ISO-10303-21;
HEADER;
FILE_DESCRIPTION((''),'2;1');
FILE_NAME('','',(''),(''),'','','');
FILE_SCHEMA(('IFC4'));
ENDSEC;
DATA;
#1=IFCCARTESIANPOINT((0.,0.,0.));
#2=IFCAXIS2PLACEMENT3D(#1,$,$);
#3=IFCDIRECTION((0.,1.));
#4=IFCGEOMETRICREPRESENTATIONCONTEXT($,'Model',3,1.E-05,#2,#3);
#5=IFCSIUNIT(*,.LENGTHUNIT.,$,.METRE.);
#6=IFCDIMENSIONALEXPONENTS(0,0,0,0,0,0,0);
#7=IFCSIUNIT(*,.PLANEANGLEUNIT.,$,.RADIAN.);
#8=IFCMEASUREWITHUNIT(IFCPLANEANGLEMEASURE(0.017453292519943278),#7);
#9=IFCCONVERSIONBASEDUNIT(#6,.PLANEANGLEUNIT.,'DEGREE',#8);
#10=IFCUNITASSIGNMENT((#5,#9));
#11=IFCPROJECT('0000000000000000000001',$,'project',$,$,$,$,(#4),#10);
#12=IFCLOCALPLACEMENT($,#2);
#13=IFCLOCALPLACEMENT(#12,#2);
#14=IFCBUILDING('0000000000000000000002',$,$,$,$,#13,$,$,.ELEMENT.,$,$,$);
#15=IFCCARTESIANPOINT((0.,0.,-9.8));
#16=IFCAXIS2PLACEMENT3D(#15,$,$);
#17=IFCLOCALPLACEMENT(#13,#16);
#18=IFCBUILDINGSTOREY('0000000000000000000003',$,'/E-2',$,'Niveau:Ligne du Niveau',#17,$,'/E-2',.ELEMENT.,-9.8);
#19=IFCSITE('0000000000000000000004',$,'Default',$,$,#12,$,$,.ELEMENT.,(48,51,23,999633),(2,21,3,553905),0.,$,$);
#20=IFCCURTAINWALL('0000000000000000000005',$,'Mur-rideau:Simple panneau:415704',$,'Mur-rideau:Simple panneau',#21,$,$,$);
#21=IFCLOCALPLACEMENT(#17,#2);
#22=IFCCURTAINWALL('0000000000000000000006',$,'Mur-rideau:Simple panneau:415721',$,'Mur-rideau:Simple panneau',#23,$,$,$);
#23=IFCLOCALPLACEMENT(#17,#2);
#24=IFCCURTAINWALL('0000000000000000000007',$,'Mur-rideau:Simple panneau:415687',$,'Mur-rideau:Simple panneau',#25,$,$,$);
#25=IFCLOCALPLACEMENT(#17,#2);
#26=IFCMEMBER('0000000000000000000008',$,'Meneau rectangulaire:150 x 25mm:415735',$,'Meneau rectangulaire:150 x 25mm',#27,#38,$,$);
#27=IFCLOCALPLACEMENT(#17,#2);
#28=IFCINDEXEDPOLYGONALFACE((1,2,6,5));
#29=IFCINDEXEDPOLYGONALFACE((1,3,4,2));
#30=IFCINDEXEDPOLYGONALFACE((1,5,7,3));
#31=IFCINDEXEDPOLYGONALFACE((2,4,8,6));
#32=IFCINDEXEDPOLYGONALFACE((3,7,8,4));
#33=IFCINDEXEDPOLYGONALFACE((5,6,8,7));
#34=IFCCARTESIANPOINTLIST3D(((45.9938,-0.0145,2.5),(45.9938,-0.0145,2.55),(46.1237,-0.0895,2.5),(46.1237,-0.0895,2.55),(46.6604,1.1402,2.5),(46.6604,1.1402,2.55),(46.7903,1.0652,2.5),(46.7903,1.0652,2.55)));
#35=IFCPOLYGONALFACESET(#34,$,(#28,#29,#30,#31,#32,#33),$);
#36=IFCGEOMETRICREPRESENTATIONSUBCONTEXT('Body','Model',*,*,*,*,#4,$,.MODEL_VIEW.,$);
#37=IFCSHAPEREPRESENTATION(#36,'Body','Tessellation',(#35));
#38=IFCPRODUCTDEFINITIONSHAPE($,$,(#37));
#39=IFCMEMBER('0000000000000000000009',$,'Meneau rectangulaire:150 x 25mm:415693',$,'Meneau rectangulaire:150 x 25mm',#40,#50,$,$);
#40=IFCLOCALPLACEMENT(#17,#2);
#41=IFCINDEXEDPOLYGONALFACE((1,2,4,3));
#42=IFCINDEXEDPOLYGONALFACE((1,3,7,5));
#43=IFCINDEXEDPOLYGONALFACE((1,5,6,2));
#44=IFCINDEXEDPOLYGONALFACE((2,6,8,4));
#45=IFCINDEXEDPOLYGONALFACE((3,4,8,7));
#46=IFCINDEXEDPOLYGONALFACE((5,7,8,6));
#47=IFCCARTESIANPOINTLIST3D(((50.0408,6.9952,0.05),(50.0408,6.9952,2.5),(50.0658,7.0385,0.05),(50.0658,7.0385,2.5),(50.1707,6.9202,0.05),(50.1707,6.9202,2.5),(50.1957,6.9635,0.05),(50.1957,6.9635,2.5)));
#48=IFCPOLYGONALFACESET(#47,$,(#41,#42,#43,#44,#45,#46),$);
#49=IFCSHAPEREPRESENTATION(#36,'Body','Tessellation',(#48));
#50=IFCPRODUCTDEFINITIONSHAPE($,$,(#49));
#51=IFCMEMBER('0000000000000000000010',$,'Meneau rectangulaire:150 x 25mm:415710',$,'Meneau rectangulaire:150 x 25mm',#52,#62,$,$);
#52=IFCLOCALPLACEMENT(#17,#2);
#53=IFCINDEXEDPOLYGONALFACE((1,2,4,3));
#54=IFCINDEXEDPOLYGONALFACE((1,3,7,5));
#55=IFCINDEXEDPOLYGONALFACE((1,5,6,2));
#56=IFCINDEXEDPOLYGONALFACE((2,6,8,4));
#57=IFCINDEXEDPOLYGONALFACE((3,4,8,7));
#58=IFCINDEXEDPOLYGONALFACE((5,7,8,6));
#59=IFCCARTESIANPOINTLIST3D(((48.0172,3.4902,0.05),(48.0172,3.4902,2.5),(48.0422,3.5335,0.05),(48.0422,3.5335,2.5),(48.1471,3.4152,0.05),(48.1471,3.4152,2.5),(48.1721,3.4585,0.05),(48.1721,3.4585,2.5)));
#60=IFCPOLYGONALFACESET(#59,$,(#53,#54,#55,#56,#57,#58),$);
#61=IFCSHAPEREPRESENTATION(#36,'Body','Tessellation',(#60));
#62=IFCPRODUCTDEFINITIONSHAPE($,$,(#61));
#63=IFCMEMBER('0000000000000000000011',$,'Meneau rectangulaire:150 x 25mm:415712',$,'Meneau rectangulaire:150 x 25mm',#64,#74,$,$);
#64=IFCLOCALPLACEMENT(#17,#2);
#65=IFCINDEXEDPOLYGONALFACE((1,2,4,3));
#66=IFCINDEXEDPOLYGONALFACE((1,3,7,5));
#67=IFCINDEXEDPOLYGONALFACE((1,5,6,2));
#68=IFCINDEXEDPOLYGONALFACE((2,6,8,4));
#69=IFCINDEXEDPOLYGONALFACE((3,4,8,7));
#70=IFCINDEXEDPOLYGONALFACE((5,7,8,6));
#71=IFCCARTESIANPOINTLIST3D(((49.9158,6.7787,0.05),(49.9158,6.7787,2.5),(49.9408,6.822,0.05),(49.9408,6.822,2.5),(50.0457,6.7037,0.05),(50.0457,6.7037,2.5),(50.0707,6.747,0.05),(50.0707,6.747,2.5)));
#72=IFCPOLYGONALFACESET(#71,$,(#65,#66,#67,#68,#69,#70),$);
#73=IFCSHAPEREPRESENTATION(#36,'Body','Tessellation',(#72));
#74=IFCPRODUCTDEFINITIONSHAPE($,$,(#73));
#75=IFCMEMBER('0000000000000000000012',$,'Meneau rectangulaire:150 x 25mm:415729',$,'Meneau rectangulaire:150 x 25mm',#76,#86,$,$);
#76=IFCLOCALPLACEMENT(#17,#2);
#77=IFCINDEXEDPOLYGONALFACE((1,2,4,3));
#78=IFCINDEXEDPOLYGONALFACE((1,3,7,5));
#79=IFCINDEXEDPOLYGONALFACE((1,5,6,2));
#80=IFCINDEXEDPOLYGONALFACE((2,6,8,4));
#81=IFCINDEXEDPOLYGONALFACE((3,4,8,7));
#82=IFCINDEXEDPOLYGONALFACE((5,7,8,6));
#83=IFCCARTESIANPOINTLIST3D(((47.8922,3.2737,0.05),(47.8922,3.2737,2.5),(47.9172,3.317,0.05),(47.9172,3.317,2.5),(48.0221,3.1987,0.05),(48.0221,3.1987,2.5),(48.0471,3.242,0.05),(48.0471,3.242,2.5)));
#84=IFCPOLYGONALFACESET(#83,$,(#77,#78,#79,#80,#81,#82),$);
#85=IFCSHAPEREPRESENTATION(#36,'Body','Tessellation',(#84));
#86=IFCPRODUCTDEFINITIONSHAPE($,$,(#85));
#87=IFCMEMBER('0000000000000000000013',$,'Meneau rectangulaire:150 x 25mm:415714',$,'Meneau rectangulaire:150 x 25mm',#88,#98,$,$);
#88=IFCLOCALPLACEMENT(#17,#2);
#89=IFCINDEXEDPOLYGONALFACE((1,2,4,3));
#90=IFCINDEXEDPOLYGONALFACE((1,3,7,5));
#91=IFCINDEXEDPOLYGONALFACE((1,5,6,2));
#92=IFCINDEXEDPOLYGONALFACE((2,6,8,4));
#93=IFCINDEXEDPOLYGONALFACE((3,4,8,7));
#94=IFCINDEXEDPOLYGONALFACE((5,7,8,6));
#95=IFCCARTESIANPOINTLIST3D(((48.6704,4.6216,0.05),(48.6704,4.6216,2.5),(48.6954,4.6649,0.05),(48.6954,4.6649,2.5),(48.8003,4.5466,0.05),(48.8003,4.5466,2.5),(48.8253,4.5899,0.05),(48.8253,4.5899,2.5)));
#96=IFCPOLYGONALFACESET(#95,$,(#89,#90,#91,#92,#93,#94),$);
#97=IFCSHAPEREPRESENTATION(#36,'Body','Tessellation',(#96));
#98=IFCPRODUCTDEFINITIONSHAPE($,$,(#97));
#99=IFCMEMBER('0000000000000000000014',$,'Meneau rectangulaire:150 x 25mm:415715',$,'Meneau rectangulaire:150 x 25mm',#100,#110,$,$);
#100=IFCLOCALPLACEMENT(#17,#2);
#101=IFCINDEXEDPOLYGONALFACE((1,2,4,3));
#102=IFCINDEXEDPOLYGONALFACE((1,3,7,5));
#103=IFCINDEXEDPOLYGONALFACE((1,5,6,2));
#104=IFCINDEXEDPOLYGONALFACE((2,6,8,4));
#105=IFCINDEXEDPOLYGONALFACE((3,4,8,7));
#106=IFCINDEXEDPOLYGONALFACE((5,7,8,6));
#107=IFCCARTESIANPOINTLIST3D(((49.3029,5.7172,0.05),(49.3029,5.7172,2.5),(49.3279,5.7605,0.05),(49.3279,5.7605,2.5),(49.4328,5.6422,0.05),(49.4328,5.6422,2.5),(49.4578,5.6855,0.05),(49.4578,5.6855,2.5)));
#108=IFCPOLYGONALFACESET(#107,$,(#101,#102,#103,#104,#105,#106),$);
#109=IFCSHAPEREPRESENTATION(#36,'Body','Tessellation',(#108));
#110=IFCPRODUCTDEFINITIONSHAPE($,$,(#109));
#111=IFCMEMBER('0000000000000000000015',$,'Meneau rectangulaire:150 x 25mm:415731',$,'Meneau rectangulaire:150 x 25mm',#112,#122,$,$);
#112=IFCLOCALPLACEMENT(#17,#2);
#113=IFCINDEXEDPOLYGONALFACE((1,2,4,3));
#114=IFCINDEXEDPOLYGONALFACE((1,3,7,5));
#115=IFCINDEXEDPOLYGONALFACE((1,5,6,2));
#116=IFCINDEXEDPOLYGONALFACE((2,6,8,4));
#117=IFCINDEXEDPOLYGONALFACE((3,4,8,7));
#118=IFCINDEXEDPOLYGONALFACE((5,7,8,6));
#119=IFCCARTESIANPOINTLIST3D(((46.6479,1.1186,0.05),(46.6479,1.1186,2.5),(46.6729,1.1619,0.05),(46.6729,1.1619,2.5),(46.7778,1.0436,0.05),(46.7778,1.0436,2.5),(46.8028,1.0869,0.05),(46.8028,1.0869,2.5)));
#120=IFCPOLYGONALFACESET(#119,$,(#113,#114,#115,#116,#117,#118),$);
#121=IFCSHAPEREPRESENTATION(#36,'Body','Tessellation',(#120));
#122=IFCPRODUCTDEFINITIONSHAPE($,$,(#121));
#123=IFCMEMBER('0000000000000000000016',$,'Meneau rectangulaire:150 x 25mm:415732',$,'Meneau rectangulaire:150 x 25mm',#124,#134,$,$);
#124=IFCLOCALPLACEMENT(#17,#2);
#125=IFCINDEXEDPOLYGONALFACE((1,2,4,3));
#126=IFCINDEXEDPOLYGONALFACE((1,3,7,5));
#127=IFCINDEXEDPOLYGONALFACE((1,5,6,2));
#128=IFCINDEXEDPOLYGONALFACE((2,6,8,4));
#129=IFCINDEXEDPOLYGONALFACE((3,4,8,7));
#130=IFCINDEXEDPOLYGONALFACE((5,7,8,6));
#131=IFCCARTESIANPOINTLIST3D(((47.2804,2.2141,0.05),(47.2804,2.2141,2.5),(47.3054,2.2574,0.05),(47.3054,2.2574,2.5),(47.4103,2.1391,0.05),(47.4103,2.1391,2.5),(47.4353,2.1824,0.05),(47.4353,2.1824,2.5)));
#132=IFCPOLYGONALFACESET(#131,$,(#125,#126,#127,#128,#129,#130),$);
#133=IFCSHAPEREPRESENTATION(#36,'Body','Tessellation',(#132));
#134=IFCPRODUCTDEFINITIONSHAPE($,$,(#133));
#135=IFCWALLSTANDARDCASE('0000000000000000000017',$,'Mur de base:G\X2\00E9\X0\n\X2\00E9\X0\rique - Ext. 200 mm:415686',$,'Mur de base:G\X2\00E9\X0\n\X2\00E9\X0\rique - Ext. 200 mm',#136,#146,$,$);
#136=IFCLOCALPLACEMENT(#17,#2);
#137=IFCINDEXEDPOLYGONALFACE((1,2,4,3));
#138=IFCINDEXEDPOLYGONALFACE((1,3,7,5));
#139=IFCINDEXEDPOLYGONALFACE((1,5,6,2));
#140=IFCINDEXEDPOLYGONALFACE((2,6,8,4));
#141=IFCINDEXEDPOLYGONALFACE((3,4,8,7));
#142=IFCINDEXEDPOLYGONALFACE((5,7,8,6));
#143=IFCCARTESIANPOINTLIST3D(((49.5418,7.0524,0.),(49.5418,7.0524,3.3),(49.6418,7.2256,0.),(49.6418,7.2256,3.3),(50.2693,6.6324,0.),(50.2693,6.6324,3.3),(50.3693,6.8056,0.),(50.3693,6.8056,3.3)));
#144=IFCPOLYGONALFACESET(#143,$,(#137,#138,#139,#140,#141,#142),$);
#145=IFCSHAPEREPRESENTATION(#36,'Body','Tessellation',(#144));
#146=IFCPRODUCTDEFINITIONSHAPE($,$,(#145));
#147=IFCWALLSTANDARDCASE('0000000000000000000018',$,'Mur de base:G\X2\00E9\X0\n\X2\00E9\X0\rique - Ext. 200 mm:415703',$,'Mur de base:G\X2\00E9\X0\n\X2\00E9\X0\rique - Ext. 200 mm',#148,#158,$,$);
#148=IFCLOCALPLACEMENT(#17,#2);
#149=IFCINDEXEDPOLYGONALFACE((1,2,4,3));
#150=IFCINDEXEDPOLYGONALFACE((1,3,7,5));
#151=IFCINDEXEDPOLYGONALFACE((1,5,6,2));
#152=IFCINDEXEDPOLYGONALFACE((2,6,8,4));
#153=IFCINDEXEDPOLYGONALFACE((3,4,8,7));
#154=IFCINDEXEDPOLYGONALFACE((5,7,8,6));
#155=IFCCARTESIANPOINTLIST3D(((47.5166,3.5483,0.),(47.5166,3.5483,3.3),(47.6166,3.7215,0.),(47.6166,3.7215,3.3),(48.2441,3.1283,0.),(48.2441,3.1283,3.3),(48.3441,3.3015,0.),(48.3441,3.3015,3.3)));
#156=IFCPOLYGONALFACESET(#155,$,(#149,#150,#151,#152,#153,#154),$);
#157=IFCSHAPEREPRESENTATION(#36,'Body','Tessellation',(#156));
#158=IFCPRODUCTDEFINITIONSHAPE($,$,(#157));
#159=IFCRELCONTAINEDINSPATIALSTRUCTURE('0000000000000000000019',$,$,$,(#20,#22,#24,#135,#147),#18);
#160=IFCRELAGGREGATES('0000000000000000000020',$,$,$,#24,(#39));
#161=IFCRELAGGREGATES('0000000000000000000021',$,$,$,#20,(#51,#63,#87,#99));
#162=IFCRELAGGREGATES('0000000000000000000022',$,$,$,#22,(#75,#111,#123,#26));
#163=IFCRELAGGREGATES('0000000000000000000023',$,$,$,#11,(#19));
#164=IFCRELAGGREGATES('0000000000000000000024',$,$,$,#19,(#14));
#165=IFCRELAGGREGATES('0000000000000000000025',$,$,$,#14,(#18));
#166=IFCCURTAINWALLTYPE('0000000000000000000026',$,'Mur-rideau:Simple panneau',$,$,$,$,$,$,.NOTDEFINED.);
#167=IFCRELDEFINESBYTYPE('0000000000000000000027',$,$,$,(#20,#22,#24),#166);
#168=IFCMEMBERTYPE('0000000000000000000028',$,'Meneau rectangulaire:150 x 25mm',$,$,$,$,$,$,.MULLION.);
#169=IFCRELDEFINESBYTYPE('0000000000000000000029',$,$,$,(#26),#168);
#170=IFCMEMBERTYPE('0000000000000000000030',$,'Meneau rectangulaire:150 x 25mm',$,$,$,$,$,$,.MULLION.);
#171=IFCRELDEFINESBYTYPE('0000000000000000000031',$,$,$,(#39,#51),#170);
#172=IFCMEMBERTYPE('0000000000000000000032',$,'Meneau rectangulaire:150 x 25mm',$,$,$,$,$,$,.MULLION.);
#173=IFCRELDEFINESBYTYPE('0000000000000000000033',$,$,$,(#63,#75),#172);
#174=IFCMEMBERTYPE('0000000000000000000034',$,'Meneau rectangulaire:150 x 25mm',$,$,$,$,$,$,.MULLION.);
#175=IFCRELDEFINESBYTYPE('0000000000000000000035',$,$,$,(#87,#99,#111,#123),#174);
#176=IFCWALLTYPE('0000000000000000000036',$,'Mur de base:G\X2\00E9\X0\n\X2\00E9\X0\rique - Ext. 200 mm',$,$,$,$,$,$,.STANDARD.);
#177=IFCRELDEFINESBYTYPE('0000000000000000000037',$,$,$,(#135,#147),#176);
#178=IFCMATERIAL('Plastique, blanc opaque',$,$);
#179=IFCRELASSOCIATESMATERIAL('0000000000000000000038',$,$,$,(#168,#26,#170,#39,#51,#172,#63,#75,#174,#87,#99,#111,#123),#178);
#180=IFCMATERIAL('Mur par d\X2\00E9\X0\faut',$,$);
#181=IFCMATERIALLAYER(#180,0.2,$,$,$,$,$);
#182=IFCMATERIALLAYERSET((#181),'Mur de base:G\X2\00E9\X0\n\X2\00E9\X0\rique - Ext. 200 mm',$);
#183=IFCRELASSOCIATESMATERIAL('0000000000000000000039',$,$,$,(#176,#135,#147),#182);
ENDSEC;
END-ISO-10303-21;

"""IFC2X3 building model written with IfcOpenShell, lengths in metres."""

from ifc_helpers import new_model, entity, si_unit, converted_unit, direction, frame, frame_2d, origin, origin_2d_with_axis, place, context, subcontext, project, spatial, rectangle, extrude, source, transform, mapped, material, layer, layer_set, layer_usage, type_object, type_shapes, element, aggregate, save


model = new_model("IFC2X3")

# Units and contexts
model_context = context("Model", 3, precision=1e-05, world=origin(), true_north=direction((0.0, 1.0)))
body_context = subcontext(model_context, "Body", "Model", "MODEL_VIEW")
ifc_project = project(units=[si_unit("LENGTHUNIT", "METRE"), converted_unit("PLANEANGLEUNIT", "DEGREE", entity("IfcPlaneAngleMeasure", 0.017453292519943278), si_unit("PLANEANGLEUNIT", "RADIAN"), dimensions=[0, 0, 0, 0, 0, 0, 0])], contexts=[model_context])

# Site, building, storey
site_placement = place(None, origin())
site = spatial("IfcSite", under=ifc_project, at=site_placement, Name="Default", CompositionType="ELEMENT", RefLatitude=(48, 51, 23, 999633), RefLongitude=(2, 21, 3, 553905), RefElevation=0.0)
building_placement = place(site_placement, origin())
building = spatial("IfcBuilding", under=site, at=building_placement, CompositionType="ELEMENT")
storey_placement = place(building_placement, frame((0.0, 0.0, -9.8)))
storey = spatial("IfcBuildingStorey", under=building, at=storey_placement, Name="/E-2", ObjectType="Niveau:Ligne du Niveau", LongName="/E-2", CompositionType="ELEMENT", Elevation=-9.8)

# Curtain walls
curtain_wall_type = type_object("IfcCurtainWallType", Name="Mur-rideau:Simple panneau", PredefinedType="NOTDEFINED")
curtain_wall_1_placement = place(storey_placement, frame((0.0, 0.0, 9.8)))
curtain_wall_1 = element("IfcCurtainWall", 1, at=curtain_wall_1_placement, inside=storey, type_object=curtain_wall_type, Name="Mur-rideau:Simple panneau:415704", ObjectType="Mur-rideau:Simple panneau")
ifc_material_1 = material(Name="Plastique, blanc opaque")
curtain_wall_2_placement = place(storey_placement, frame((0.0, 0.0, 9.8)))
curtain_wall_2 = element("IfcCurtainWall", 2, at=curtain_wall_2_placement, inside=storey, type_object=curtain_wall_type, Name="Mur-rideau:Simple panneau:415721", ObjectType="Mur-rideau:Simple panneau")

# Curtain wall
curtain_wall_3_placement = place(storey_placement, frame((0.0, 0.0, 9.8)))
curtain_wall_3 = element("IfcCurtainWall", 3, at=curtain_wall_3_placement, inside=storey, type_object=curtain_wall_type, Name="Mur-rideau:Simple panneau:415687", ObjectType="Mur-rideau:Simple panneau")

# Members
member_type_1 = type_object("IfcMemberType", Name="Meneau rectangulaire:150 x 25mm", PredefinedType="MULLION", material=ifc_material_1)
shared_shape_1 = source(origin(), body_context, "Body", "SweptSolid", [
    extrude(rectangle(XDim=0.05, YDim=0.15, at=origin_2d_with_axis()), frame((-0.025, 0.0, -1.3333), z_axis=(0.0, 0.0, 1.0), x_axis=(-1.0, 0.0, 0.0)), (0.0, 0.0, 1.0), 1.3333),
])
type_shapes(member_type_1, [shared_shape_1])
member_1_placement = place(curtain_wall_2_placement, frame((46.7254, 1.1027, -7.25), z_axis=(0.5, 0.866025, 0.0), x_axis=(0.0, 0.0, 1.0)))
member_1 = element("IfcMember", 4, at=member_1_placement, type_object=member_type_1, material=ifc_material_1, Name="Meneau rectangulaire:150 x 25mm:415735", ObjectType="Meneau rectangulaire:150 x 25mm", context=body_context, shape_type="MappedRepresentation", body=[
    mapped(shared_shape_1, transform((0.0, 0.0, 0.0), scale=1.0)),
])
member_type_2 = type_object("IfcMemberType", Name="Meneau rectangulaire:150 x 25mm", PredefinedType="MULLION", material=ifc_material_1)
shared_shape_2 = source(origin(), body_context, "Body", "SweptSolid", [
    extrude(rectangle(XDim=0.05, YDim=0.15, at=origin_2d_with_axis()), frame((-0.025, 0.0, -2.45), z_axis=(0.0, 0.0, 1.0), x_axis=(-1.0, 0.0, 0.0)), (0.0, 0.0, 1.0), 2.45),
])
type_shapes(member_type_2, [shared_shape_2])
member_2_placement = place(curtain_wall_3_placement, frame((50.1058, 6.9577, -7.3), z_axis=(0.0, 0.0, 1.0), x_axis=(-0.5, -0.866025, 0.0)))
member_2 = element("IfcMember", 5, at=member_2_placement, type_object=member_type_2, material=ifc_material_1, Name="Meneau rectangulaire:150 x 25mm:415693", ObjectType="Meneau rectangulaire:150 x 25mm", context=body_context, shape_type="MappedRepresentation", body=[
    mapped(shared_shape_2, transform((0.0, 0.0, 0.0), scale=1.0)),
])
member_3_placement = place(curtain_wall_1_placement, frame((48.0822, 3.4527, -7.3), z_axis=(0.0, 0.0, 1.0), x_axis=(-0.5, -0.866025, 0.0)))
member_3 = element("IfcMember", 6, at=member_3_placement, type_object=member_type_2, material=ifc_material_1, Name="Meneau rectangulaire:150 x 25mm:415710", ObjectType="Meneau rectangulaire:150 x 25mm", context=body_context, shape_type="MappedRepresentation", body=[
    mapped(shared_shape_2, transform((0.0, 0.0, 0.0), scale=1.0)),
])
member_type_3 = type_object("IfcMemberType", Name="Meneau rectangulaire:150 x 25mm", PredefinedType="MULLION", material=ifc_material_1)
shared_shape_3 = source(origin(), body_context, "Body", "SweptSolid", [
    extrude(rectangle(XDim=0.05, YDim=0.15, at=origin_2d_with_axis()), frame((-0.025, 0.0, -2.45), z_axis=(0.0, 0.0, 1.0), x_axis=(-1.0, 0.0, 0.0)), (0.0, 0.0, 1.0), 2.45),
])
type_shapes(member_type_3, [shared_shape_3])
member_4_placement = place(curtain_wall_1_placement, frame((50.0058, 6.7845, -9.75), z_axis=(0.0, 0.0, -1.0), x_axis=(0.5, 0.866025, 0.0)))
member_4 = element("IfcMember", 7, at=member_4_placement, type_object=member_type_3, material=ifc_material_1, Name="Meneau rectangulaire:150 x 25mm:415712", ObjectType="Meneau rectangulaire:150 x 25mm", context=body_context, shape_type="MappedRepresentation", body=[
    mapped(shared_shape_3, transform((0.0, 0.0, 0.0), scale=1.0)),
])
member_5_placement = place(curtain_wall_2_placement, frame((47.9822, 3.2795, -9.75), z_axis=(0.0, 0.0, -1.0), x_axis=(0.5, 0.866025, 0.0)))
member_5 = element("IfcMember", 8, at=member_5_placement, type_object=member_type_3, material=ifc_material_1, Name="Meneau rectangulaire:150 x 25mm:415729", ObjectType="Meneau rectangulaire:150 x 25mm", context=body_context, shape_type="MappedRepresentation", body=[
    mapped(shared_shape_3, transform((0.0, 0.0, 0.0), scale=1.0)),
])
member_type_4 = type_object("IfcMemberType", Name="Meneau rectangulaire:150 x 25mm", PredefinedType="MULLION", material=ifc_material_1)
shared_shape_4 = source(origin(), body_context, "Body", "SweptSolid", [
    extrude(rectangle(XDim=0.05, YDim=0.15, at=origin_2d_with_axis()), frame((0.0, 0.0, -2.45), z_axis=(0.0, 0.0, 1.0), x_axis=(-1.0, 0.0, 0.0)), (0.0, 0.0, 1.0), 2.45),
])
type_shapes(member_type_4, [shared_shape_4])
member_6_placement = place(curtain_wall_1_placement, frame((48.7479, 4.6058, -9.75), z_axis=(0.0, 0.0, -1.0), x_axis=(0.5, 0.866025, 0.0)))
member_6 = element("IfcMember", 9, at=member_6_placement, type_object=member_type_4, material=ifc_material_1, Name="Meneau rectangulaire:150 x 25mm:415714", ObjectType="Meneau rectangulaire:150 x 25mm", context=body_context, shape_type="MappedRepresentation", body=[
    mapped(shared_shape_4, transform((0.0, 0.0, 0.0), scale=1.0)),
])
member_7_placement = place(curtain_wall_1_placement, frame((49.3804, 5.7013, -9.75), z_axis=(0.0, 0.0, -1.0), x_axis=(0.5, 0.866025, 0.0)))
member_7 = element("IfcMember", 10, at=member_7_placement, type_object=member_type_4, material=ifc_material_1, Name="Meneau rectangulaire:150 x 25mm:415715", ObjectType="Meneau rectangulaire:150 x 25mm", context=body_context, shape_type="MappedRepresentation", body=[
    mapped(shared_shape_4, transform((0.0, 0.0, 0.0), scale=1.0)),
])
member_8_placement = place(curtain_wall_2_placement, frame((46.7254, 1.1027, -9.75), z_axis=(0.0, 0.0, -1.0), x_axis=(0.5, 0.866025, 0.0)))
member_8 = element("IfcMember", 11, at=member_8_placement, type_object=member_type_4, material=ifc_material_1, Name="Meneau rectangulaire:150 x 25mm:415731", ObjectType="Meneau rectangulaire:150 x 25mm", context=body_context, shape_type="MappedRepresentation", body=[
    mapped(shared_shape_4, transform((0.0, 0.0, 0.0), scale=1.0)),
])
member_9_placement = place(curtain_wall_2_placement, frame((47.3579, 2.1982, -9.75), z_axis=(0.0, 0.0, -1.0), x_axis=(0.5, 0.866025, 0.0)))
member_9 = element("IfcMember", 12, at=member_9_placement, type_object=member_type_4, material=ifc_material_1, Name="Meneau rectangulaire:150 x 25mm:415732", ObjectType="Meneau rectangulaire:150 x 25mm", context=body_context, shape_type="MappedRepresentation", body=[
    mapped(shared_shape_4, transform((0.0, 0.0, 0.0), scale=1.0)),
])

aggregate(curtain_wall_3, [member_2])
aggregate(curtain_wall_1, [member_3, member_4, member_6, member_7])
aggregate(curtain_wall_2, [member_5, member_8, member_9, member_1])

# Walls
ifc_material_2 = material(Name="Mur par défaut")
ifc_layer_1 = layer(ifc_material_2, 0.2)
ifc_layer_set_1 = layer_set([ifc_layer_1], Name="Mur de base:Générique - Ext. 200 mm")
ifc_layer_usage_1 = layer_usage(ifc_layer_set_1, "AXIS2", "NEGATIVE", 0.1)
wall_type = type_object("IfcWallType", Name="Mur de base:Générique - Ext. 200 mm", PredefinedType="STANDARD", material=ifc_layer_set_1)
wall_1_placement = place(storey_placement, frame((49.5918, 7.139, 0.0), z_axis=(0.0, 0.0, 1.0), x_axis=(0.866025, -0.5, 0.0)))
element("IfcWallStandardCase", 13, at=wall_1_placement, inside=storey, type_object=wall_type, material=ifc_layer_usage_1, Name="Mur de base:Générique - Ext. 200 mm:415686", ObjectType="Mur de base:Générique - Ext. 200 mm", context=body_context, shape_type="SweptSolid", body=[
    extrude(rectangle(XDim=0.84, YDim=0.2, at=frame_2d((0.42, 0.0), x_axis=(-1.0, 0.0))), origin(), (0.0, 0.0, 1.0), 3.3),
])
ifc_layer_usage_2 = layer_usage(ifc_layer_set_1, "AXIS2", "NEGATIVE", 0.1)
wall_2_placement = place(storey_placement, frame((47.5666, 3.6349, 0.0), z_axis=(0.0, 0.0, 1.0), x_axis=(0.866025, -0.5, 0.0)))
element("IfcWallStandardCase", 14, at=wall_2_placement, inside=storey, type_object=wall_type, material=ifc_layer_usage_2, Name="Mur de base:Générique - Ext. 200 mm:415703", ObjectType="Mur de base:Générique - Ext. 200 mm", context=body_context, shape_type="SweptSolid", body=[
    extrude(rectangle(XDim=0.84, YDim=0.2, at=frame_2d((0.42, 0.0), x_axis=(-1.0, 0.0))), origin(), (0.0, 0.0, 1.0), 3.3),
])

save(model, "model.ifc")
